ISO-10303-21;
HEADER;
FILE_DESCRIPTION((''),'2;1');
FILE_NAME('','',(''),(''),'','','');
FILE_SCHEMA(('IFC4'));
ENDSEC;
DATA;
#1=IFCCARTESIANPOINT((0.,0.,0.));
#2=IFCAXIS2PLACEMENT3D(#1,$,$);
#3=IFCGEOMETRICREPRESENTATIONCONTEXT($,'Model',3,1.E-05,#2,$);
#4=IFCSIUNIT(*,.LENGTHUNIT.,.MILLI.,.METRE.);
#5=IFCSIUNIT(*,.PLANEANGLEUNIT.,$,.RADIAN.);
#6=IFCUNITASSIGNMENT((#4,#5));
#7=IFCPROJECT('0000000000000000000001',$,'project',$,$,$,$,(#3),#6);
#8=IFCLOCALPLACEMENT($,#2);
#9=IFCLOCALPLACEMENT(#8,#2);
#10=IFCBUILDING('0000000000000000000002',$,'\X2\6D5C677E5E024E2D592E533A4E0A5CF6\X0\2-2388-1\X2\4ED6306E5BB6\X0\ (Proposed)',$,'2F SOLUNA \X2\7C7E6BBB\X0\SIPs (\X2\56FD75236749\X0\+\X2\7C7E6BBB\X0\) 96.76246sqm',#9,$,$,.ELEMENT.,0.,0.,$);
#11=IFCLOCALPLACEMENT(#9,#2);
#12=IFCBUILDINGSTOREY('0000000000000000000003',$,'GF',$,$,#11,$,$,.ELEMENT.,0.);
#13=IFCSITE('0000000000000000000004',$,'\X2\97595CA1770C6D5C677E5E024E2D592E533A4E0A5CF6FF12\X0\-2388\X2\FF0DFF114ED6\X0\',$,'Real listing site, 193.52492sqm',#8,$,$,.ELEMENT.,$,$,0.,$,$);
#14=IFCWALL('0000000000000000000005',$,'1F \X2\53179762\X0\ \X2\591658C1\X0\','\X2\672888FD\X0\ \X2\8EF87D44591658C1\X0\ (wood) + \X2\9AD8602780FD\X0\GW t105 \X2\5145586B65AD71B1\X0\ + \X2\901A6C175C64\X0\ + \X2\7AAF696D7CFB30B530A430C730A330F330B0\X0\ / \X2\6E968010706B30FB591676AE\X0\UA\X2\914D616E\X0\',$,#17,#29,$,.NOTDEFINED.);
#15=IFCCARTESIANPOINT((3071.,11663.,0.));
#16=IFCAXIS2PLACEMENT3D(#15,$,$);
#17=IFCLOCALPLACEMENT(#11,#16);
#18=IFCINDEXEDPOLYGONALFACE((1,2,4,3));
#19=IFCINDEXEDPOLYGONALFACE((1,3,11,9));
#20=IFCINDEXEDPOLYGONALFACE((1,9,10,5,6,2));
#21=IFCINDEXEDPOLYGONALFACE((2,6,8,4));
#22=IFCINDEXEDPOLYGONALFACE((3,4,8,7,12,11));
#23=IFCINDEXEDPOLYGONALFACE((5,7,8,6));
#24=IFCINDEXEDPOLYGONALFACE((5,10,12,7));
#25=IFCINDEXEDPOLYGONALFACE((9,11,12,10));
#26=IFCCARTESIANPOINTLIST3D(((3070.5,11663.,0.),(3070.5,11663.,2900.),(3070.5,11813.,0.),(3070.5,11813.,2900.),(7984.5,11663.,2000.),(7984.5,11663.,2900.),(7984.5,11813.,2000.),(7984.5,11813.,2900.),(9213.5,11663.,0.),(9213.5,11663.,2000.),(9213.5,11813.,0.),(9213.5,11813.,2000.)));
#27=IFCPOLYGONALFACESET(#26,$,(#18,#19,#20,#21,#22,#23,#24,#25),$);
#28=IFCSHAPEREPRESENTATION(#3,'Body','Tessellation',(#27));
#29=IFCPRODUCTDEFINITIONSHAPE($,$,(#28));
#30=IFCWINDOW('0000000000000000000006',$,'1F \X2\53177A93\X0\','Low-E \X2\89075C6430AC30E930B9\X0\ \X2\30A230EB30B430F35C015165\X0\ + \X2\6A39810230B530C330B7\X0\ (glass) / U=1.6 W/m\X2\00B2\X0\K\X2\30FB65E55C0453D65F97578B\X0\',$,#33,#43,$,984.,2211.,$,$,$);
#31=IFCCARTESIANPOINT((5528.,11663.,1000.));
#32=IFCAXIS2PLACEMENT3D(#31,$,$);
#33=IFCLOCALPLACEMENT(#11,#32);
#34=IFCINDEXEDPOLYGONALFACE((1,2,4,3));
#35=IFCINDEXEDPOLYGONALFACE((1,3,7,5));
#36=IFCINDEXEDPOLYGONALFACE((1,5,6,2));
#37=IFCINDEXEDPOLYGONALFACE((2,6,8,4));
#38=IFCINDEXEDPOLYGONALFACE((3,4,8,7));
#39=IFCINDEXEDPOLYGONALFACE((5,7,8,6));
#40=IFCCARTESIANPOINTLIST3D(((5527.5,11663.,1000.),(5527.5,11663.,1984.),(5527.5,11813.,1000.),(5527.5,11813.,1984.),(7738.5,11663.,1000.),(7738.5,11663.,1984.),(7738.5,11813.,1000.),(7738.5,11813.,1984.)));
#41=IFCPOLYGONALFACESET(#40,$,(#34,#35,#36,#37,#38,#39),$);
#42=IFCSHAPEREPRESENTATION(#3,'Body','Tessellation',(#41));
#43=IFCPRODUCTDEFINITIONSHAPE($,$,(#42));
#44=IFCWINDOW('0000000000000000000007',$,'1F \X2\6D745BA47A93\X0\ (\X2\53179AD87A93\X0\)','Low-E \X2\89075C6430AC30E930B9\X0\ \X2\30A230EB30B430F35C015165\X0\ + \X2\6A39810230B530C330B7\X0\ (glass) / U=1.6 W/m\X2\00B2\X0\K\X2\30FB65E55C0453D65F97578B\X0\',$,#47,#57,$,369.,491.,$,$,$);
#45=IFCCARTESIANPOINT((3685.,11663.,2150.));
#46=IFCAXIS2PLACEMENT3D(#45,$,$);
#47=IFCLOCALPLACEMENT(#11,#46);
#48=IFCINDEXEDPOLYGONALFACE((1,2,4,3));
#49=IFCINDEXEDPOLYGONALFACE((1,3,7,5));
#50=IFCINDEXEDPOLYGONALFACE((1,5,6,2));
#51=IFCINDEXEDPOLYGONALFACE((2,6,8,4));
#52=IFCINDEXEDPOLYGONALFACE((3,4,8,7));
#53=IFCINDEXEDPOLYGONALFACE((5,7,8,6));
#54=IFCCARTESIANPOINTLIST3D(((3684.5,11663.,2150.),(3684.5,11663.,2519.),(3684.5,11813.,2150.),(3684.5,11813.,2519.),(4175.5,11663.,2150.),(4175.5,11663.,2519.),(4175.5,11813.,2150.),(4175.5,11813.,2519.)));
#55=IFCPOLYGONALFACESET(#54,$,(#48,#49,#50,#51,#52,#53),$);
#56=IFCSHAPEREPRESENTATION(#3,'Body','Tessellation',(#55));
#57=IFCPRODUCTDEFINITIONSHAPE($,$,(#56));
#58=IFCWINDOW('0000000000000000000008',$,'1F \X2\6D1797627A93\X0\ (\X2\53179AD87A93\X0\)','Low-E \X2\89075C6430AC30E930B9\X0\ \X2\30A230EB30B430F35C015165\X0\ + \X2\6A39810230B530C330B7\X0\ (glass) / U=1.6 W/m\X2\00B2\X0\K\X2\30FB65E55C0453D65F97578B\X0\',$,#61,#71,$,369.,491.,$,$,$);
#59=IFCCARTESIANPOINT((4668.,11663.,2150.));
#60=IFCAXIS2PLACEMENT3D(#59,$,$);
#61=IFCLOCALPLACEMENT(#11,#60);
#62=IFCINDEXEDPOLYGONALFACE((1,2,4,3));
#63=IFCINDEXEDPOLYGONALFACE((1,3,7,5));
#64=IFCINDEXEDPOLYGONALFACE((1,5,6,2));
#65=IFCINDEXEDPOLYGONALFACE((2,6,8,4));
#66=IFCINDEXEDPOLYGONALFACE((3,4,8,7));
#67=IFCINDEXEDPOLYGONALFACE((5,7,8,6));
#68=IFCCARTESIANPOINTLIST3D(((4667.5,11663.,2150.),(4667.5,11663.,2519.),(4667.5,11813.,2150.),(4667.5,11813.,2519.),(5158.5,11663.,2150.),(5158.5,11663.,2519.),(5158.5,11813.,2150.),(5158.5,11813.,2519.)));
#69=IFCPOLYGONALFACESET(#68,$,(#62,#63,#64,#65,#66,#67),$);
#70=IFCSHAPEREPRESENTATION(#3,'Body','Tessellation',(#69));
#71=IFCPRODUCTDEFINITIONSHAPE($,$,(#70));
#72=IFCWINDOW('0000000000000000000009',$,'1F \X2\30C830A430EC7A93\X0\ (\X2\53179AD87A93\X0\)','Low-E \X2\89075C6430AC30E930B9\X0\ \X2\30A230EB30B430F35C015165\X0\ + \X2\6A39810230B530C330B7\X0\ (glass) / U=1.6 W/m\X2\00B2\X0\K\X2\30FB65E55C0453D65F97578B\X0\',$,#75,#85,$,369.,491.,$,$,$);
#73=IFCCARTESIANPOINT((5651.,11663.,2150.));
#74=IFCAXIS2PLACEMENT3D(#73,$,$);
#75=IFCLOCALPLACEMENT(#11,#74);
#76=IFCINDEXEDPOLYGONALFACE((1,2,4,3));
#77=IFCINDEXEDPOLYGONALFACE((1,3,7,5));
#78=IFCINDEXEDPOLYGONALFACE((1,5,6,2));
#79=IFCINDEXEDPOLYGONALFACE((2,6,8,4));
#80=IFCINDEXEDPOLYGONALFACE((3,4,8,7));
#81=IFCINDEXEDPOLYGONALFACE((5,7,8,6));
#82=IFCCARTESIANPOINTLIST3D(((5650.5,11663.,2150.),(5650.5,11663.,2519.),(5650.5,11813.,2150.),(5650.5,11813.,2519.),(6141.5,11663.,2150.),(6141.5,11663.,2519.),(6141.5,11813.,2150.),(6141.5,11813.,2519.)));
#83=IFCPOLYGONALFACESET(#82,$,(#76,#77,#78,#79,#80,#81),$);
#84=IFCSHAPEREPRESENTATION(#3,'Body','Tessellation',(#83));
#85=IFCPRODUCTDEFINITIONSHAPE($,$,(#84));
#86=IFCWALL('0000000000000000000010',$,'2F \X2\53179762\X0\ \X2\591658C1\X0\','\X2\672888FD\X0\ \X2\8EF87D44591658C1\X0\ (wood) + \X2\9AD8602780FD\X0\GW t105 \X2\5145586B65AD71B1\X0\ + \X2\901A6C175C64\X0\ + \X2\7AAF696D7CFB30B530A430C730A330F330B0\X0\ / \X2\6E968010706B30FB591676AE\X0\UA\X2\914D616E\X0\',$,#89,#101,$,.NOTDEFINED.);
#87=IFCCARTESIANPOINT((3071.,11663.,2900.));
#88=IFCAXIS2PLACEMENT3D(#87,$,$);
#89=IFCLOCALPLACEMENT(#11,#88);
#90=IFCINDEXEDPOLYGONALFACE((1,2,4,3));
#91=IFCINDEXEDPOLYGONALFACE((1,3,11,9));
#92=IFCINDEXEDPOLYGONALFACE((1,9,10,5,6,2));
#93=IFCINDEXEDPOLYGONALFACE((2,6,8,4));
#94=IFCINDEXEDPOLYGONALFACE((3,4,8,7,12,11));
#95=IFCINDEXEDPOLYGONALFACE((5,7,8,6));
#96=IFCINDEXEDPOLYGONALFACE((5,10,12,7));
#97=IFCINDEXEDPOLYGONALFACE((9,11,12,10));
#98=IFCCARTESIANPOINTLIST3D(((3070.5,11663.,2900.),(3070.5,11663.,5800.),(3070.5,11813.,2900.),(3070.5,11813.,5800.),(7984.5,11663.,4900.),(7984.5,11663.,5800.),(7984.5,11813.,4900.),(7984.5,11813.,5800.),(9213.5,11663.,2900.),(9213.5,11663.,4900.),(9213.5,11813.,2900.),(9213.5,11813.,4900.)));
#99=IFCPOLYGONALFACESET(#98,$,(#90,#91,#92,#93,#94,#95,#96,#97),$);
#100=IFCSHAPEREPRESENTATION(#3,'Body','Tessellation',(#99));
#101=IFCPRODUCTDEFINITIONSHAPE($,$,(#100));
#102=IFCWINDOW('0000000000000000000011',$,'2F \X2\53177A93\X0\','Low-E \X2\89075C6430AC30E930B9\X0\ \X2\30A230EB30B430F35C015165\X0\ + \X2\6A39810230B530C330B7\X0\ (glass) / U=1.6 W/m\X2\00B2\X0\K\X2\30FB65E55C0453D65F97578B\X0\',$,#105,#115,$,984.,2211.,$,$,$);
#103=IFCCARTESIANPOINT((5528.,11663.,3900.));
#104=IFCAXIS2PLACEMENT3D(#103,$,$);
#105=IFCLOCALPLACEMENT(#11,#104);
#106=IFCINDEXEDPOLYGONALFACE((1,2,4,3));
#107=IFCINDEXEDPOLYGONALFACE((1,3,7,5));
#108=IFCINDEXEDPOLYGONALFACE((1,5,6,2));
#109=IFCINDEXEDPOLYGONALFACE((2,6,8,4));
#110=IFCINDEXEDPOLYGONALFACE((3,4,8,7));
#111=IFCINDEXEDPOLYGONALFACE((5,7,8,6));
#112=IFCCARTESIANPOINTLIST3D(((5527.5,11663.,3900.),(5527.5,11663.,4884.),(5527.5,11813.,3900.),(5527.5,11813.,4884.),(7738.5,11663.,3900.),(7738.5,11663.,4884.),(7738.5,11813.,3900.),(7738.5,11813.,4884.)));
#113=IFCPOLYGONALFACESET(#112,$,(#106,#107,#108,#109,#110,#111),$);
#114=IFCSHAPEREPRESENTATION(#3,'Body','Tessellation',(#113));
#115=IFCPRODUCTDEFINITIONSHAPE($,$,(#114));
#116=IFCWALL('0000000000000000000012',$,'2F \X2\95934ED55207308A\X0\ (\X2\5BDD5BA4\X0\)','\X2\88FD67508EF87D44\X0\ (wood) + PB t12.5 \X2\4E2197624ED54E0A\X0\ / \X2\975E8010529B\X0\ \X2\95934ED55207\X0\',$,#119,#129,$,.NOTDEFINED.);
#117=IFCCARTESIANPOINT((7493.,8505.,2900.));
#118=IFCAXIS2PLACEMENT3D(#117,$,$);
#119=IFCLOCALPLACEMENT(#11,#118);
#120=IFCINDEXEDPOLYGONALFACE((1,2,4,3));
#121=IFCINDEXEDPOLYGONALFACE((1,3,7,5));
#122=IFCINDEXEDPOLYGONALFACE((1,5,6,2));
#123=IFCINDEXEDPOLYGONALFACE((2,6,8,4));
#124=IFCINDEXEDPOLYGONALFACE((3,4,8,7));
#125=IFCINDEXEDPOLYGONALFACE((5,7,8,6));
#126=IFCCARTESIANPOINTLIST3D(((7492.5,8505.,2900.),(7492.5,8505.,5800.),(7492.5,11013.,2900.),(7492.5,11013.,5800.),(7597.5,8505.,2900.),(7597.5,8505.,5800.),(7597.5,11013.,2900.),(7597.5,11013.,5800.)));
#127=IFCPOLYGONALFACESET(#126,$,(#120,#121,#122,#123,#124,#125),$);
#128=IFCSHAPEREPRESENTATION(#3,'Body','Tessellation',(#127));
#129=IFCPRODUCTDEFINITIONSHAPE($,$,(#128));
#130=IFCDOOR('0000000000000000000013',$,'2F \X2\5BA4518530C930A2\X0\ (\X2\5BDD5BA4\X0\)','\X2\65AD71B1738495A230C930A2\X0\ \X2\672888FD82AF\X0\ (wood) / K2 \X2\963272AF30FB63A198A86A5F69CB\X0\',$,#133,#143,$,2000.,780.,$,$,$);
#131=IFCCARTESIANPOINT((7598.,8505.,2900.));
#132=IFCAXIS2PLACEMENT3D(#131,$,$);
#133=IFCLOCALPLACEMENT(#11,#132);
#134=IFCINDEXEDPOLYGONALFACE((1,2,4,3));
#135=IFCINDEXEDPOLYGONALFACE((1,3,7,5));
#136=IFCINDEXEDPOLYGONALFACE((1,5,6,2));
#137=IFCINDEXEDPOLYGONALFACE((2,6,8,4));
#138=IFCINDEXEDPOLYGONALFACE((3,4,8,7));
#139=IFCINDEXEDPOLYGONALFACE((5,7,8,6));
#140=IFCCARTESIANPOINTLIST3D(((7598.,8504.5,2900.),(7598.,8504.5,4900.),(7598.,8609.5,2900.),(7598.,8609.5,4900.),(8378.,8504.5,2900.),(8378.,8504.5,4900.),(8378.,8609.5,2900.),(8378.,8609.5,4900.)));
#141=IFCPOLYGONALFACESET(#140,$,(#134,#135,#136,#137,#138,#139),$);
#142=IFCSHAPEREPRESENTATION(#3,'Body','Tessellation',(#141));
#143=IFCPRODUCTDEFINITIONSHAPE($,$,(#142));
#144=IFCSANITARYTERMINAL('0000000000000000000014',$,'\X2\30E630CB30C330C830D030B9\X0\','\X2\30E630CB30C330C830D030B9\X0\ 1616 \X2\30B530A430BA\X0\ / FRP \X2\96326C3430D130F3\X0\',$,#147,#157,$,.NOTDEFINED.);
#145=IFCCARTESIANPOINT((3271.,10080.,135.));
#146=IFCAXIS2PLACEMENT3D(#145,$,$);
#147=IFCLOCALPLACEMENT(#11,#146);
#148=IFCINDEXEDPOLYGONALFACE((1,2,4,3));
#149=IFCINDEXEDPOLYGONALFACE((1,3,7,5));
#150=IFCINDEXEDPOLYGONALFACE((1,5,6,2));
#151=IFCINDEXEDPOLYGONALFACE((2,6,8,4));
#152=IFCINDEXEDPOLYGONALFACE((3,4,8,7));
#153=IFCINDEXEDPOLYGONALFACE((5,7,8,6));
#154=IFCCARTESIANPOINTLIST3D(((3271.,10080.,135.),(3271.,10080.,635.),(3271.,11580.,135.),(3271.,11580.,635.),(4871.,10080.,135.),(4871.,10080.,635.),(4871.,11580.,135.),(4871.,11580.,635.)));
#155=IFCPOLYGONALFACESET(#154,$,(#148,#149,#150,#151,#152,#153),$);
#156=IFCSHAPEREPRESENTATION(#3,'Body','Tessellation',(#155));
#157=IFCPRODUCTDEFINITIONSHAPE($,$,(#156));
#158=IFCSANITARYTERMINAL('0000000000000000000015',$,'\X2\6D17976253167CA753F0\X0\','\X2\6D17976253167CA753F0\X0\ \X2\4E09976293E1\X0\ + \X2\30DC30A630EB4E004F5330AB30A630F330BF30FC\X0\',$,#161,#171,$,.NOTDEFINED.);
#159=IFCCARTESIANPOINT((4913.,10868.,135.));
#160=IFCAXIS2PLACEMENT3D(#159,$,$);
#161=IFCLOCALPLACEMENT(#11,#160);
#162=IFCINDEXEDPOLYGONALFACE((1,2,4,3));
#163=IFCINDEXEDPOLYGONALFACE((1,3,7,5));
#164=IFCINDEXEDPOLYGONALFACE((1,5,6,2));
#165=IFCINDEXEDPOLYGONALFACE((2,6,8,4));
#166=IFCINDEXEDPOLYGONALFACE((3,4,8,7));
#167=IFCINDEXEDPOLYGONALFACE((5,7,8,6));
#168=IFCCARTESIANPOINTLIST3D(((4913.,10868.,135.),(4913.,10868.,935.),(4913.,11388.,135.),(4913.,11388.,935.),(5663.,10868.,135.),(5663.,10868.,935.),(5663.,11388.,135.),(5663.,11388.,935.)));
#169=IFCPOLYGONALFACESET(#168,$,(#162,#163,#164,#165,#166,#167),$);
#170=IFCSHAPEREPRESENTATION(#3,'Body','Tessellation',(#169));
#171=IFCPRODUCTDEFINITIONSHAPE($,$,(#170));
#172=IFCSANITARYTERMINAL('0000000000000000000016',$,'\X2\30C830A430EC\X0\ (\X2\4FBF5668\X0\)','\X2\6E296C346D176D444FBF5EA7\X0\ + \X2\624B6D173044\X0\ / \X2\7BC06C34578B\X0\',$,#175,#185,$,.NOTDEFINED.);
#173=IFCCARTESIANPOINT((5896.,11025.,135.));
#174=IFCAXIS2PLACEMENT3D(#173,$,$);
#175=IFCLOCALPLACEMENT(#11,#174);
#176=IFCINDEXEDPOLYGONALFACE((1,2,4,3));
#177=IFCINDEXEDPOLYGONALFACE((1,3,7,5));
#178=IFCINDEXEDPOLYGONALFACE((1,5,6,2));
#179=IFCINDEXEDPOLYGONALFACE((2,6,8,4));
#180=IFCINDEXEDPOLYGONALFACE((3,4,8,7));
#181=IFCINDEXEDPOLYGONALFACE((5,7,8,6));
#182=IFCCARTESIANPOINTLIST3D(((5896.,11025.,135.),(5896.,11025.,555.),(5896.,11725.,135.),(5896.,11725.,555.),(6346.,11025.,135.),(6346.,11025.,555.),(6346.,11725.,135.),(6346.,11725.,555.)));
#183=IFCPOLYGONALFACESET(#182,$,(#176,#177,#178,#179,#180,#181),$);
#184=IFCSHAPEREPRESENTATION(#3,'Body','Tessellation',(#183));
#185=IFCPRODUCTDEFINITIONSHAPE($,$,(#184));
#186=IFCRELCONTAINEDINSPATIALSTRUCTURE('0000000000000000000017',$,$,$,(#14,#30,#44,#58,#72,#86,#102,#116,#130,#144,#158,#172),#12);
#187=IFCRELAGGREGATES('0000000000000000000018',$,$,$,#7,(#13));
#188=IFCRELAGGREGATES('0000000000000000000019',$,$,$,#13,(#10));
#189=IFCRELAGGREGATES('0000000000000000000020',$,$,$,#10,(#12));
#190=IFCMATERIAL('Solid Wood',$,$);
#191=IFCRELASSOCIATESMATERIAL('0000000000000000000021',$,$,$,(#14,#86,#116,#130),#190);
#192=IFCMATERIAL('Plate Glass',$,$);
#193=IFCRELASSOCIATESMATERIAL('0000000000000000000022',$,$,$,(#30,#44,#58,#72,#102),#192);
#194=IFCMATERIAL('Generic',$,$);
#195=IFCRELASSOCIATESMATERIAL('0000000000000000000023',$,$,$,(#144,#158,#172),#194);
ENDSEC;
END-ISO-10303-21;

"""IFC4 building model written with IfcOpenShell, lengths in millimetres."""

from ifc_helpers import new_model, si_unit, frame, frame_2d, origin, place, context, project, spatial, rectangle, extrude, material, element, fill, save


model = new_model("IFC4")

# Units and contexts
model_context = context("Model", 3, precision=1e-05, world=origin())
ifc_project = project(units=[si_unit("LENGTHUNIT", "METRE", prefix="MILLI"), si_unit("PLANEANGLEUNIT", "RADIAN")], contexts=[model_context])

# Site, building, storey
site_placement = place(None, origin())
site = spatial("IfcSite", under=ifc_project, at=site_placement, Name="静岡県浜松市中央区上島２-2388－１他", ObjectType="Real listing site, 193.52492sqm", CompositionType="ELEMENT", RefElevation=0.0)
building_placement = place(site_placement, origin())
building = spatial("IfcBuilding", under=site, at=building_placement, Name="浜松市中央区上島2-2388-1他の家 (Proposed)", ObjectType="2F SOLUNA 籾殻SIPs (国産杉+籾殻) 96.76246sqm", CompositionType="ELEMENT", ElevationOfRefHeight=0.0, ElevationOfTerrain=0.0)
storey_placement = place(building_placement, origin())
storey = spatial("IfcBuildingStorey", under=building, at=storey_placement, Name="GF", CompositionType="ELEMENT", Elevation=0.0)

# Wall, openings, windows
ifc_material_1 = material(Name="Solid Wood")
wall_1_placement = place(storey_placement, frame((3071.0, 11663.0, 0.0)))
wall_1 = element("IfcWall", 1, at=wall_1_placement, inside=storey, material=ifc_material_1, Name="1F 北面 外壁", Description="木製 軸組外壁 (wood) + 高性能GW t105 充填断熱 + 通気層 + 窯業系サイディング / 準耐火・外皮UA配慮", PredefinedType="NOTDEFINED", context=model_context, shape_type="SweptSolid", body=[
    extrude(rectangle(XDim=6143.0, YDim=150.0, at=frame_2d((3071.0, 75.0))), frame((3071.0, 11663.0, 0.0)), (0.0, 0.0, 1.0), 2900.0),
])
opening_1_placement = place(storey_placement, frame((5528.0, 11663.0, 1000.0)))
opening_1 = element("IfcOpeningElement", 2, at=opening_1_placement, cuts=wall_1, PredefinedType="NOTDEFINED", context=model_context, shape_type="SweptSolid", body=[
    extrude(rectangle(XDim=2211.0, YDim=150.0, at=frame_2d((1105.0, 75.0))), frame((5528.0, 11663.0, 1000.0)), (0.0, 0.0, 1.0), 984.0),
])
opening_2_placement = place(storey_placement, frame((3685.0, 11663.0, 2150.0)))
opening_2 = element("IfcOpeningElement", 3, at=opening_2_placement, cuts=wall_1, PredefinedType="NOTDEFINED", context=model_context, shape_type="SweptSolid", body=[
    extrude(rectangle(XDim=491.0, YDim=150.0, at=frame_2d((245.0, 75.0))), frame((3685.0, 11663.0, 2150.0)), (0.0, 0.0, 1.0), 369.0),
])
opening_3_placement = place(storey_placement, frame((4668.0, 11663.0, 2150.0)))
opening_3 = element("IfcOpeningElement", 4, at=opening_3_placement, cuts=wall_1, PredefinedType="NOTDEFINED", context=model_context, shape_type="SweptSolid", body=[
    extrude(rectangle(XDim=491.0, YDim=150.0, at=frame_2d((245.0, 75.0))), frame((4668.0, 11663.0, 2150.0)), (0.0, 0.0, 1.0), 369.0),
])
opening_4_placement = place(storey_placement, frame((5651.0, 11663.0, 2150.0)))
opening_4 = element("IfcOpeningElement", 5, at=opening_4_placement, cuts=wall_1, PredefinedType="NOTDEFINED", context=model_context, shape_type="SweptSolid", body=[
    extrude(rectangle(XDim=491.0, YDim=150.0, at=frame_2d((245.0, 75.0))), frame((5651.0, 11663.0, 2150.0)), (0.0, 0.0, 1.0), 369.0),
])
ifc_material_2 = material(Name="Plate Glass")
window_1_placement = place(storey_placement, frame((5528.0, 11663.0, 1000.0)))
window_1 = element("IfcWindow", 6, at=window_1_placement, inside=storey, material=ifc_material_2, Name="1F 北窓", Description="Low-E 複層ガラス アルゴン封入 + 樹脂サッシ (glass) / U=1.6 W/m²K・日射取得型", OverallHeight=984.0, OverallWidth=2211.0, context=model_context, shape_type="SweptSolid", body=[
    extrude(rectangle(XDim=2211.0, YDim=150.0, at=frame_2d((1105.0, 75.0))), frame((5528.0, 11663.0, 1000.0)), (0.0, 0.0, 1.0), 984.0),
])
fill(opening_1, window_1)
window_2_placement = place(storey_placement, frame((3685.0, 11663.0, 2150.0)))
window_2 = element("IfcWindow", 7, at=window_2_placement, inside=storey, material=ifc_material_2, Name="1F 浴室窓 (北高窓)", Description="Low-E 複層ガラス アルゴン封入 + 樹脂サッシ (glass) / U=1.6 W/m²K・日射取得型", OverallHeight=369.0, OverallWidth=491.0, context=model_context, shape_type="SweptSolid", body=[
    extrude(rectangle(XDim=491.0, YDim=150.0, at=frame_2d((245.0, 75.0))), frame((3685.0, 11663.0, 2150.0)), (0.0, 0.0, 1.0), 369.0),
])
fill(opening_2, window_2)
window_3_placement = place(storey_placement, frame((4668.0, 11663.0, 2150.0)))
window_3 = element("IfcWindow", 8, at=window_3_placement, inside=storey, material=ifc_material_2, Name="1F 洗面窓 (北高窓)", Description="Low-E 複層ガラス アルゴン封入 + 樹脂サッシ (glass) / U=1.6 W/m²K・日射取得型", OverallHeight=369.0, OverallWidth=491.0, context=model_context, shape_type="SweptSolid", body=[
    extrude(rectangle(XDim=491.0, YDim=150.0, at=frame_2d((245.0, 75.0))), frame((4668.0, 11663.0, 2150.0)), (0.0, 0.0, 1.0), 369.0),
])
fill(opening_3, window_3)
window_4_placement = place(storey_placement, frame((5651.0, 11663.0, 2150.0)))
window_4 = element("IfcWindow", 9, at=window_4_placement, inside=storey, material=ifc_material_2, Name="1F トイレ窓 (北高窓)", Description="Low-E 複層ガラス アルゴン封入 + 樹脂サッシ (glass) / U=1.6 W/m²K・日射取得型", OverallHeight=369.0, OverallWidth=491.0, context=model_context, shape_type="SweptSolid", body=[
    extrude(rectangle(XDim=491.0, YDim=150.0, at=frame_2d((245.0, 75.0))), frame((5651.0, 11663.0, 2150.0)), (0.0, 0.0, 1.0), 369.0),
])
fill(opening_4, window_4)

# Wall, opening, window
wall_2_placement = place(storey_placement, frame((3071.0, 11663.0, 2900.0)))
wall_2 = element("IfcWall", 10, at=wall_2_placement, inside=storey, material=ifc_material_1, Name="2F 北面 外壁", Description="木製 軸組外壁 (wood) + 高性能GW t105 充填断熱 + 通気層 + 窯業系サイディング / 準耐火・外皮UA配慮", PredefinedType="NOTDEFINED", context=model_context, shape_type="SweptSolid", body=[
    extrude(rectangle(XDim=6143.0, YDim=150.0, at=frame_2d((3071.0, 75.0))), frame((3071.0, 11663.0, 2900.0)), (0.0, 0.0, 1.0), 2900.0),
])
opening_5_placement = place(storey_placement, frame((5528.0, 11663.0, 3900.0)))
opening_5 = element("IfcOpeningElement", 11, at=opening_5_placement, cuts=wall_2, PredefinedType="NOTDEFINED", context=model_context, shape_type="SweptSolid", body=[
    extrude(rectangle(XDim=2211.0, YDim=150.0, at=frame_2d((1105.0, 75.0))), frame((5528.0, 11663.0, 3900.0)), (0.0, 0.0, 1.0), 984.0),
])
window_5_placement = place(storey_placement, frame((5528.0, 11663.0, 3900.0)))
window_5 = element("IfcWindow", 12, at=window_5_placement, inside=storey, material=ifc_material_2, Name="2F 北窓", Description="Low-E 複層ガラス アルゴン封入 + 樹脂サッシ (glass) / U=1.6 W/m²K・日射取得型", OverallHeight=984.0, OverallWidth=2211.0, context=model_context, shape_type="SweptSolid", body=[
    extrude(rectangle(XDim=2211.0, YDim=150.0, at=frame_2d((1105.0, 75.0))), frame((5528.0, 11663.0, 3900.0)), (0.0, 0.0, 1.0), 984.0),
])
fill(opening_5, window_5)

# Wall
wall_3_placement = place(storey_placement, frame((7493.0, 8505.0, 2900.0)))
element("IfcWall", 13, at=wall_3_placement, inside=storey, material=ifc_material_1, Name="2F 間仕切り (寝室)", Description="製材軸組 (wood) + PB t12.5 両面仕上 / 非耐力 間仕切", PredefinedType="NOTDEFINED", context=model_context, shape_type="SweptSolid", body=[
    extrude(rectangle(XDim=105.0, YDim=2508.0, at=frame_2d((52.0, 1254.0))), frame((7493.0, 8505.0, 2900.0)), (0.0, 0.0, 1.0), 2900.0),
])

# Door
door_1_placement = place(storey_placement, frame((7598.0, 8505.0, 2900.0)))
element("IfcDoor", 14, at=door_1_placement, inside=storey, material=ifc_material_1, Name="2F 室内ドア (寝室)", Description="断熱玄関ドア 木製芯 (wood) / K2 防犯・採風機構", OverallHeight=2000.0, OverallWidth=780.0, context=model_context, shape_type="SweptSolid", body=[
    extrude(rectangle(XDim=780.0, YDim=105.0, at=frame_2d((390.0, 52.0))), frame((7598.0, 8505.0, 2900.0)), (0.0, 0.0, 1.0), 2000.0),
])

# Sanitary terminals
ifc_material_3 = material(Name="Generic")
sanitary_terminal_1_placement = place(storey_placement, frame((3271.0, 10080.0, 135.0)))
element("IfcSanitaryTerminal", 15, at=sanitary_terminal_1_placement, inside=storey, material=ifc_material_3, Name="ユニットバス", Description="ユニットバス 1616 サイズ / FRP 防水パン", PredefinedType="NOTDEFINED", context=model_context, shape_type="SweptSolid", body=[
    extrude(rectangle(XDim=1600.0, YDim=1500.0, at=frame_2d((800.0, 750.0))), frame((3271.0, 10080.0, 135.0)), (0.0, 0.0, 1.0), 500.0),
])
sanitary_terminal_2_placement = place(storey_placement, frame((4913.0, 10868.0, 135.0)))
element("IfcSanitaryTerminal", 16, at=sanitary_terminal_2_placement, inside=storey, material=ifc_material_3, Name="洗面化粧台", Description="洗面化粧台 三面鏡 + ボウル一体カウンター", PredefinedType="NOTDEFINED", context=model_context, shape_type="SweptSolid", body=[
    extrude(rectangle(XDim=750.0, YDim=520.0, at=frame_2d((375.0, 260.0))), frame((4913.0, 10868.0, 135.0)), (0.0, 0.0, 1.0), 800.0),
])
sanitary_terminal_3_placement = place(storey_placement, frame((5896.0, 11025.0, 135.0)))
element("IfcSanitaryTerminal", 17, at=sanitary_terminal_3_placement, inside=storey, material=ifc_material_3, Name="トイレ (便器)", Description="温水洗浄便座 + 手洗い / 節水型", PredefinedType="NOTDEFINED", context=model_context, shape_type="SweptSolid", body=[
    extrude(rectangle(XDim=450.0, YDim=700.0, at=frame_2d((225.0, 350.0))), frame((5896.0, 11025.0, 135.0)), (0.0, 0.0, 1.0), 420.0),
])

save(model, "model.ifc")
